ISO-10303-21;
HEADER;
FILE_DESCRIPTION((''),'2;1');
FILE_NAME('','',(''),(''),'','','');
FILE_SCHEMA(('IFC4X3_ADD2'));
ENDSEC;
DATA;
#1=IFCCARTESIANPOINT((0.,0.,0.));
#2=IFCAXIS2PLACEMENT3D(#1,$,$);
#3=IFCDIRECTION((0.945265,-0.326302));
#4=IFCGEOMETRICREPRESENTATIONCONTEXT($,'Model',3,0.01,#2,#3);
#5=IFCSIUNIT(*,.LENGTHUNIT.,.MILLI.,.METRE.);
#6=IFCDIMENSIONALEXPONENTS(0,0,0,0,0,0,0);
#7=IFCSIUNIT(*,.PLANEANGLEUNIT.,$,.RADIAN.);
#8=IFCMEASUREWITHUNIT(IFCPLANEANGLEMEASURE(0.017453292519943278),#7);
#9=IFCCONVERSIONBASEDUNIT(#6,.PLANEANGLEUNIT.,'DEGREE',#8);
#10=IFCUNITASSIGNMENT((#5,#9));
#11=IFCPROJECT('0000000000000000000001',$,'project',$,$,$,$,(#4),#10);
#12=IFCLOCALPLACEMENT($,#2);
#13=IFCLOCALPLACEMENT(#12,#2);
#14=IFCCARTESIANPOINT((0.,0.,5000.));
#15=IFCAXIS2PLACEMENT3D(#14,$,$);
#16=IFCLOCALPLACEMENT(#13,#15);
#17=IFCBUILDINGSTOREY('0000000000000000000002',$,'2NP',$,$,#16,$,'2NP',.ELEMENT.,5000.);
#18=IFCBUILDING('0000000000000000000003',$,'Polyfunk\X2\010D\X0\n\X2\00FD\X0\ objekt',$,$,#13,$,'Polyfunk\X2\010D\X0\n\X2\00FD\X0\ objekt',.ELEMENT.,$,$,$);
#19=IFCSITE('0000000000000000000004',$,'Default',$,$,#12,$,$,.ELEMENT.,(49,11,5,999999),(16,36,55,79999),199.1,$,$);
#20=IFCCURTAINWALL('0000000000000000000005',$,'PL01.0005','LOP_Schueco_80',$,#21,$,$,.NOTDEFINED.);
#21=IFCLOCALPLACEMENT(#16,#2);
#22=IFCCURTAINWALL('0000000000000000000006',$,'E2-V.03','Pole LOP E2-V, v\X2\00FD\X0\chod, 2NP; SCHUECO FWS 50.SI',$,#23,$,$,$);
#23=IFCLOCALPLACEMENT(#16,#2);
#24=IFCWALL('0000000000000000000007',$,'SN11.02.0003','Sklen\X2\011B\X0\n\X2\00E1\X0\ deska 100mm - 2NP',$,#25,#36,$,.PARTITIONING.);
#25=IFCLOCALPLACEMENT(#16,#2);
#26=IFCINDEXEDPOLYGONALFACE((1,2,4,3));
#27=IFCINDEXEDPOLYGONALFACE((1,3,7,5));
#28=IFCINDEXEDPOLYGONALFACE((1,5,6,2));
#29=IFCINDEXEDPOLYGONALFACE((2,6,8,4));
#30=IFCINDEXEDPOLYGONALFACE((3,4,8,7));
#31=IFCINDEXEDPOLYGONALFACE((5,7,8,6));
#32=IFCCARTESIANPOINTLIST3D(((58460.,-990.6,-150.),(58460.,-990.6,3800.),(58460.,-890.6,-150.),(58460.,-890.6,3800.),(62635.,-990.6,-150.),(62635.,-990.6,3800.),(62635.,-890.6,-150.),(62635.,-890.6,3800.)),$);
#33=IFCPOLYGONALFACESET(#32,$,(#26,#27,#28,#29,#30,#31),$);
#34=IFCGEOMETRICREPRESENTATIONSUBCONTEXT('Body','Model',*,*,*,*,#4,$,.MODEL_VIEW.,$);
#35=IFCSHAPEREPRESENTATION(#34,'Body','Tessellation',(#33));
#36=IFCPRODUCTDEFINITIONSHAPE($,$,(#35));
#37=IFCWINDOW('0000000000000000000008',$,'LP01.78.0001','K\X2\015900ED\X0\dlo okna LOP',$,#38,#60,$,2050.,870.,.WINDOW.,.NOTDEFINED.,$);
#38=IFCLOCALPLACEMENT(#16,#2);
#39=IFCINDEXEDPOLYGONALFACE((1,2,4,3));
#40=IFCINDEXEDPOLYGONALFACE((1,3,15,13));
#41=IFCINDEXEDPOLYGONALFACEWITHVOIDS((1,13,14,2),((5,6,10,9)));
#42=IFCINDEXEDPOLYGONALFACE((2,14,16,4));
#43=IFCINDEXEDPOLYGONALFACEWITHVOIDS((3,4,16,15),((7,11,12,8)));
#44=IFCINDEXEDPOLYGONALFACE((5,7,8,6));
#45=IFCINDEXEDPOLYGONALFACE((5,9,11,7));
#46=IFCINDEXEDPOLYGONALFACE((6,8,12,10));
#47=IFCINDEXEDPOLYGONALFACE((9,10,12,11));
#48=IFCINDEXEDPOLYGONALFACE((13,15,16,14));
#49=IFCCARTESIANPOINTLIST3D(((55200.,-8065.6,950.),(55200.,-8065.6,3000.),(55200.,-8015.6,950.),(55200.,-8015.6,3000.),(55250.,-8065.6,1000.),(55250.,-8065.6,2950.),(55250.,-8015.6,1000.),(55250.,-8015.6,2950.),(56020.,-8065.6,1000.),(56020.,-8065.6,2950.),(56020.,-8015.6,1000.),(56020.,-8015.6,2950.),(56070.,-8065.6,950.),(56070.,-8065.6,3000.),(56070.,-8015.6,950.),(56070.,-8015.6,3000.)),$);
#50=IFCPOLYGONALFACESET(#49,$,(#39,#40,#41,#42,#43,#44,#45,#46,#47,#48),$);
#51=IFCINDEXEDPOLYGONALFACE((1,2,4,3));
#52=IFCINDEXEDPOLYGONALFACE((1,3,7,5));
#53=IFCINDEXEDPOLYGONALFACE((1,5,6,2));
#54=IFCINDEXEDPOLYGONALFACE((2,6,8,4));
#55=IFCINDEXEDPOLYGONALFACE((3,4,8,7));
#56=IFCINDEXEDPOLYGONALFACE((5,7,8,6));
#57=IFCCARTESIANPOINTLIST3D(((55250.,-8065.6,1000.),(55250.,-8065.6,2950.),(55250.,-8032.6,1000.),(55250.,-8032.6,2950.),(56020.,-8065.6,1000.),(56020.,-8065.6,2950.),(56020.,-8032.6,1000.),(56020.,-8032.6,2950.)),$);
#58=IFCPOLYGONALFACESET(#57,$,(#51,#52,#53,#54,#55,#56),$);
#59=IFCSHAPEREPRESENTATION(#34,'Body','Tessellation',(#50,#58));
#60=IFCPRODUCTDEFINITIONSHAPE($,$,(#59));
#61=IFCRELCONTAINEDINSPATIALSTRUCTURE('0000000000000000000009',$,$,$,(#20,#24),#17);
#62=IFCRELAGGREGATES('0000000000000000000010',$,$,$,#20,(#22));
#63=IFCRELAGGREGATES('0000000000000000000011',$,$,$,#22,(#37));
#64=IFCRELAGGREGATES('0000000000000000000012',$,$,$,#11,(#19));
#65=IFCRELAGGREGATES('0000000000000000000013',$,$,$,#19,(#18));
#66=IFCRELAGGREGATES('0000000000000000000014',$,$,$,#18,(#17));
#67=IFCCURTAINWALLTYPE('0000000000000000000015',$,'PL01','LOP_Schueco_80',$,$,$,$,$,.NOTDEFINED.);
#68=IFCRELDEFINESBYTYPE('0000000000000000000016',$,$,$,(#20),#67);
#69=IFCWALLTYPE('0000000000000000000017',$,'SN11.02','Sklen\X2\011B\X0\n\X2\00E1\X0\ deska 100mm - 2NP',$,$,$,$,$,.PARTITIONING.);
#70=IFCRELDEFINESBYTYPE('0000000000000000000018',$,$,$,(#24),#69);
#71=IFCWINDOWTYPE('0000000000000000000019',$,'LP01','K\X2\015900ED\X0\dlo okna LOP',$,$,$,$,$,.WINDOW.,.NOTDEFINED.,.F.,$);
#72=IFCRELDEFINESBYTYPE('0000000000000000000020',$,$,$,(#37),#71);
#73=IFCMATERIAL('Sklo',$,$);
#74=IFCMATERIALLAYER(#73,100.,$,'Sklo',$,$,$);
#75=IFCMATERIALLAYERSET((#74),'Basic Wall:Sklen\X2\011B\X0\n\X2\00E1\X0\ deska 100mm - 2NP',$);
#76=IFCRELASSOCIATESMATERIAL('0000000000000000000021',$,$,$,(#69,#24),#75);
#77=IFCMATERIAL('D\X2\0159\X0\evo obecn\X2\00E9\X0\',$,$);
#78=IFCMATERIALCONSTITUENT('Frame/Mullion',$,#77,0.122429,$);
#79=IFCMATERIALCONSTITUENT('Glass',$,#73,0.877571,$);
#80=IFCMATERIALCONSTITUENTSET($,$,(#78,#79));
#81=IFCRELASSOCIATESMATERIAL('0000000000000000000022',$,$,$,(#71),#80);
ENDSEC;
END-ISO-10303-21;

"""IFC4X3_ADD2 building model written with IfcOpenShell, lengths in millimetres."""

from ifc_helpers import new_model, entity, si_unit, converted_unit, direction, frame, frame_2d, origin, place, context, subcontext, project, spatial, polyline, rectangle, outline, extrude, clip, bounded_halfspace, source, transform, mapped, material, layer, layer_set, constituent, constituent_set, type_object, type_shapes, element, aggregate, save


model = new_model("IFC4X3_ADD2")

# Units and contexts
model_context = context("Model", 3, precision=0.01, world=origin(), true_north=direction((0.945265, -0.326302)))
body_context = subcontext(model_context, "Body", "Model", "MODEL_VIEW")
ifc_project = project(units=[si_unit("LENGTHUNIT", "METRE", prefix="MILLI"), converted_unit("PLANEANGLEUNIT", "DEGREE", entity("IfcPlaneAngleMeasure", 0.017453292519943278), si_unit("PLANEANGLEUNIT", "RADIAN"), dimensions=[0, 0, 0, 0, 0, 0, 0])], contexts=[model_context])

# Site, building, storey
site_placement = place(None, origin())
site = spatial("IfcSite", under=ifc_project, at=site_placement, Name="Default", CompositionType="ELEMENT", RefLatitude=(49, 11, 5, 999999), RefLongitude=(16, 36, 55, 79999), RefElevation=199.1)
building_placement = place(site_placement, origin())
building = spatial("IfcBuilding", under=site, at=building_placement, Name="Polyfunkčný objekt", LongName="Polyfunkčný objekt", CompositionType="ELEMENT")
storey_placement = place(building_placement, frame((0.0, 0.0, 5000.0)))
storey = spatial("IfcBuildingStorey", under=building, at=storey_placement, Name="2NP", LongName="2NP", CompositionType="ELEMENT", Elevation=5000.0)

# Curtain walls
curtain_wall_type = type_object("IfcCurtainWallType", Name="PL01", Description="LOP_Schueco_80", PredefinedType="NOTDEFINED")
curtain_wall_1_placement = place(storey_placement, frame((0.0, 0.0, -5000.0)))
curtain_wall_1 = element("IfcCurtainWall", 1, at=curtain_wall_1_placement, inside=storey, type_object=curtain_wall_type, Name="PL01.0005", Description="LOP_Schueco_80", PredefinedType="NOTDEFINED")
curtain_wall_2 = element("IfcCurtainWall", 2, Name="E2-V.03", Description="Pole LOP E2-V, východ, 2NP; SCHUECO FWS 50.SI")
aggregate(curtain_wall_1, [curtain_wall_2])
ifc_material_1 = material(Name="Sklo")

# Wall
ifc_layer_1 = layer(ifc_material_1, 100.0, Name="Sklo")
ifc_layer_set_1 = layer_set([ifc_layer_1], Name="Basic Wall:Skleněná deska 100mm - 2NP")
wall_type_1 = type_object("IfcWallType", Name="SN11.02", Description="Skleněná deska 100mm - 2NP", PredefinedType="PARTITIONING", material=ifc_layer_set_1)
wall_1_placement = place(storey_placement, frame((58460.0, -940.6, -150.0)))
element("IfcWall", 3, at=wall_1_placement, inside=storey, type_object=wall_type_1, material=ifc_layer_set_1, Name="SN11.02.0003", Description="Skleněná deska 100mm - 2NP", PredefinedType="PARTITIONING", context=body_context, shape_type="Clipping", body=[
    clip(clip(extrude(rectangle(XDim=4175.0, YDim=100.0, at=frame_2d((2087.5, 0.0), x_axis=(-1.0, 0.0))), origin(), (0.0, 0.0, 1.0), 3950.0), bounded_halfspace(frame((4175.0, -50.0, 0.0), z_axis=(0.0, 0.0, 1.0), x_axis=(-1.0, 0.0, 0.0)), True, frame((4175.0, -50.0, 0.0)), polyline([(0.0, 0.0), (0.0, 100.0), (-4075.0, 100.0), (-4175.0, 100.0), (-4175.0, 0.0), (0.0, 0.0)]))), bounded_halfspace(frame((0.0, -50.0, 3950.0), z_axis=(0.0, 0.0, -1.0), x_axis=(1.0, 0.0, 0.0)), True, frame((0.0, -50.0, 3950.0)), polyline([(0.0, 0.0), (4175.0, 0.0), (4175.0, 100.0), (100.0, 100.0), (0.0, 100.0), (0.0, 0.0)]))),
])

# Window
ifc_material_2 = material(Name="Dřevo obecné")
ifc_constituent_1 = constituent(ifc_material_2, Name="Frame/Mullion", fraction=0.122429)
ifc_constituent_2 = constituent(ifc_material_1, Name="Glass", fraction=0.877571)
ifc_constituent_set = constituent_set(constituents=[ifc_constituent_1, ifc_constituent_2])
window_type = type_object("IfcWindowType", Name="LP01", Description="Křídlo okna LOP", ParameterTakesPrecedence=False, PartitioningType="NOTDEFINED", PredefinedType="WINDOW", material=ifc_constituent_set)
shared_shape_1 = source(origin(), body_context, "Body", "SweptSolid", [
    extrude(outline(polyline([(-1025.0, -435.0), (1025.0, -435.0), (1025.0, 435.0), (-1025.0, 435.0), (-1025.0, -435.0)]), holes=[polyline([(-975.0, -385.0), (-975.0, 385.0), (975.0, 385.0), (975.0, -385.0), (-975.0, -385.0)])]), frame((0.0, 50.0, 1025.0), z_axis=(0.0, -1.0, 0.0), x_axis=(0.0, 0.0, -1.0)), (0.0, 0.0, 1.0), 50.0),
    extrude(rectangle(XDim=770.0, YDim=33.0, at=frame_2d((0.0, 0.0), x_axis=(1.0, 0.0))), frame((0.0, 33.5, 50.0), z_axis=(0.0, 0.0, 1.0), x_axis=(-1.0, 0.0, 0.0)), (0.0, 0.0, 1.0), 1950.0),
])
type_shapes(window_type, [shared_shape_1])
window_placement = place(curtain_wall_1_placement, frame((55635.0, -8015.6, 5950.0), z_axis=(0.0, 0.0, 1.0), x_axis=(-1.0, 0.0, 0.0)))
window = element("IfcWindow", 4, at=window_placement, type_object=window_type, Name="LP01.78.0001", Description="Křídlo okna LOP", OverallHeight=2050.0, OverallWidth=870.0, PartitioningType="NOTDEFINED", PredefinedType="WINDOW", context=body_context, shape_type="MappedRepresentation", body=[
    mapped(shared_shape_1, transform((0.0, 0.0, 0.0), scale=1.0)),
])
aggregate(curtain_wall_2, [window])

save(model, "model.ifc")
